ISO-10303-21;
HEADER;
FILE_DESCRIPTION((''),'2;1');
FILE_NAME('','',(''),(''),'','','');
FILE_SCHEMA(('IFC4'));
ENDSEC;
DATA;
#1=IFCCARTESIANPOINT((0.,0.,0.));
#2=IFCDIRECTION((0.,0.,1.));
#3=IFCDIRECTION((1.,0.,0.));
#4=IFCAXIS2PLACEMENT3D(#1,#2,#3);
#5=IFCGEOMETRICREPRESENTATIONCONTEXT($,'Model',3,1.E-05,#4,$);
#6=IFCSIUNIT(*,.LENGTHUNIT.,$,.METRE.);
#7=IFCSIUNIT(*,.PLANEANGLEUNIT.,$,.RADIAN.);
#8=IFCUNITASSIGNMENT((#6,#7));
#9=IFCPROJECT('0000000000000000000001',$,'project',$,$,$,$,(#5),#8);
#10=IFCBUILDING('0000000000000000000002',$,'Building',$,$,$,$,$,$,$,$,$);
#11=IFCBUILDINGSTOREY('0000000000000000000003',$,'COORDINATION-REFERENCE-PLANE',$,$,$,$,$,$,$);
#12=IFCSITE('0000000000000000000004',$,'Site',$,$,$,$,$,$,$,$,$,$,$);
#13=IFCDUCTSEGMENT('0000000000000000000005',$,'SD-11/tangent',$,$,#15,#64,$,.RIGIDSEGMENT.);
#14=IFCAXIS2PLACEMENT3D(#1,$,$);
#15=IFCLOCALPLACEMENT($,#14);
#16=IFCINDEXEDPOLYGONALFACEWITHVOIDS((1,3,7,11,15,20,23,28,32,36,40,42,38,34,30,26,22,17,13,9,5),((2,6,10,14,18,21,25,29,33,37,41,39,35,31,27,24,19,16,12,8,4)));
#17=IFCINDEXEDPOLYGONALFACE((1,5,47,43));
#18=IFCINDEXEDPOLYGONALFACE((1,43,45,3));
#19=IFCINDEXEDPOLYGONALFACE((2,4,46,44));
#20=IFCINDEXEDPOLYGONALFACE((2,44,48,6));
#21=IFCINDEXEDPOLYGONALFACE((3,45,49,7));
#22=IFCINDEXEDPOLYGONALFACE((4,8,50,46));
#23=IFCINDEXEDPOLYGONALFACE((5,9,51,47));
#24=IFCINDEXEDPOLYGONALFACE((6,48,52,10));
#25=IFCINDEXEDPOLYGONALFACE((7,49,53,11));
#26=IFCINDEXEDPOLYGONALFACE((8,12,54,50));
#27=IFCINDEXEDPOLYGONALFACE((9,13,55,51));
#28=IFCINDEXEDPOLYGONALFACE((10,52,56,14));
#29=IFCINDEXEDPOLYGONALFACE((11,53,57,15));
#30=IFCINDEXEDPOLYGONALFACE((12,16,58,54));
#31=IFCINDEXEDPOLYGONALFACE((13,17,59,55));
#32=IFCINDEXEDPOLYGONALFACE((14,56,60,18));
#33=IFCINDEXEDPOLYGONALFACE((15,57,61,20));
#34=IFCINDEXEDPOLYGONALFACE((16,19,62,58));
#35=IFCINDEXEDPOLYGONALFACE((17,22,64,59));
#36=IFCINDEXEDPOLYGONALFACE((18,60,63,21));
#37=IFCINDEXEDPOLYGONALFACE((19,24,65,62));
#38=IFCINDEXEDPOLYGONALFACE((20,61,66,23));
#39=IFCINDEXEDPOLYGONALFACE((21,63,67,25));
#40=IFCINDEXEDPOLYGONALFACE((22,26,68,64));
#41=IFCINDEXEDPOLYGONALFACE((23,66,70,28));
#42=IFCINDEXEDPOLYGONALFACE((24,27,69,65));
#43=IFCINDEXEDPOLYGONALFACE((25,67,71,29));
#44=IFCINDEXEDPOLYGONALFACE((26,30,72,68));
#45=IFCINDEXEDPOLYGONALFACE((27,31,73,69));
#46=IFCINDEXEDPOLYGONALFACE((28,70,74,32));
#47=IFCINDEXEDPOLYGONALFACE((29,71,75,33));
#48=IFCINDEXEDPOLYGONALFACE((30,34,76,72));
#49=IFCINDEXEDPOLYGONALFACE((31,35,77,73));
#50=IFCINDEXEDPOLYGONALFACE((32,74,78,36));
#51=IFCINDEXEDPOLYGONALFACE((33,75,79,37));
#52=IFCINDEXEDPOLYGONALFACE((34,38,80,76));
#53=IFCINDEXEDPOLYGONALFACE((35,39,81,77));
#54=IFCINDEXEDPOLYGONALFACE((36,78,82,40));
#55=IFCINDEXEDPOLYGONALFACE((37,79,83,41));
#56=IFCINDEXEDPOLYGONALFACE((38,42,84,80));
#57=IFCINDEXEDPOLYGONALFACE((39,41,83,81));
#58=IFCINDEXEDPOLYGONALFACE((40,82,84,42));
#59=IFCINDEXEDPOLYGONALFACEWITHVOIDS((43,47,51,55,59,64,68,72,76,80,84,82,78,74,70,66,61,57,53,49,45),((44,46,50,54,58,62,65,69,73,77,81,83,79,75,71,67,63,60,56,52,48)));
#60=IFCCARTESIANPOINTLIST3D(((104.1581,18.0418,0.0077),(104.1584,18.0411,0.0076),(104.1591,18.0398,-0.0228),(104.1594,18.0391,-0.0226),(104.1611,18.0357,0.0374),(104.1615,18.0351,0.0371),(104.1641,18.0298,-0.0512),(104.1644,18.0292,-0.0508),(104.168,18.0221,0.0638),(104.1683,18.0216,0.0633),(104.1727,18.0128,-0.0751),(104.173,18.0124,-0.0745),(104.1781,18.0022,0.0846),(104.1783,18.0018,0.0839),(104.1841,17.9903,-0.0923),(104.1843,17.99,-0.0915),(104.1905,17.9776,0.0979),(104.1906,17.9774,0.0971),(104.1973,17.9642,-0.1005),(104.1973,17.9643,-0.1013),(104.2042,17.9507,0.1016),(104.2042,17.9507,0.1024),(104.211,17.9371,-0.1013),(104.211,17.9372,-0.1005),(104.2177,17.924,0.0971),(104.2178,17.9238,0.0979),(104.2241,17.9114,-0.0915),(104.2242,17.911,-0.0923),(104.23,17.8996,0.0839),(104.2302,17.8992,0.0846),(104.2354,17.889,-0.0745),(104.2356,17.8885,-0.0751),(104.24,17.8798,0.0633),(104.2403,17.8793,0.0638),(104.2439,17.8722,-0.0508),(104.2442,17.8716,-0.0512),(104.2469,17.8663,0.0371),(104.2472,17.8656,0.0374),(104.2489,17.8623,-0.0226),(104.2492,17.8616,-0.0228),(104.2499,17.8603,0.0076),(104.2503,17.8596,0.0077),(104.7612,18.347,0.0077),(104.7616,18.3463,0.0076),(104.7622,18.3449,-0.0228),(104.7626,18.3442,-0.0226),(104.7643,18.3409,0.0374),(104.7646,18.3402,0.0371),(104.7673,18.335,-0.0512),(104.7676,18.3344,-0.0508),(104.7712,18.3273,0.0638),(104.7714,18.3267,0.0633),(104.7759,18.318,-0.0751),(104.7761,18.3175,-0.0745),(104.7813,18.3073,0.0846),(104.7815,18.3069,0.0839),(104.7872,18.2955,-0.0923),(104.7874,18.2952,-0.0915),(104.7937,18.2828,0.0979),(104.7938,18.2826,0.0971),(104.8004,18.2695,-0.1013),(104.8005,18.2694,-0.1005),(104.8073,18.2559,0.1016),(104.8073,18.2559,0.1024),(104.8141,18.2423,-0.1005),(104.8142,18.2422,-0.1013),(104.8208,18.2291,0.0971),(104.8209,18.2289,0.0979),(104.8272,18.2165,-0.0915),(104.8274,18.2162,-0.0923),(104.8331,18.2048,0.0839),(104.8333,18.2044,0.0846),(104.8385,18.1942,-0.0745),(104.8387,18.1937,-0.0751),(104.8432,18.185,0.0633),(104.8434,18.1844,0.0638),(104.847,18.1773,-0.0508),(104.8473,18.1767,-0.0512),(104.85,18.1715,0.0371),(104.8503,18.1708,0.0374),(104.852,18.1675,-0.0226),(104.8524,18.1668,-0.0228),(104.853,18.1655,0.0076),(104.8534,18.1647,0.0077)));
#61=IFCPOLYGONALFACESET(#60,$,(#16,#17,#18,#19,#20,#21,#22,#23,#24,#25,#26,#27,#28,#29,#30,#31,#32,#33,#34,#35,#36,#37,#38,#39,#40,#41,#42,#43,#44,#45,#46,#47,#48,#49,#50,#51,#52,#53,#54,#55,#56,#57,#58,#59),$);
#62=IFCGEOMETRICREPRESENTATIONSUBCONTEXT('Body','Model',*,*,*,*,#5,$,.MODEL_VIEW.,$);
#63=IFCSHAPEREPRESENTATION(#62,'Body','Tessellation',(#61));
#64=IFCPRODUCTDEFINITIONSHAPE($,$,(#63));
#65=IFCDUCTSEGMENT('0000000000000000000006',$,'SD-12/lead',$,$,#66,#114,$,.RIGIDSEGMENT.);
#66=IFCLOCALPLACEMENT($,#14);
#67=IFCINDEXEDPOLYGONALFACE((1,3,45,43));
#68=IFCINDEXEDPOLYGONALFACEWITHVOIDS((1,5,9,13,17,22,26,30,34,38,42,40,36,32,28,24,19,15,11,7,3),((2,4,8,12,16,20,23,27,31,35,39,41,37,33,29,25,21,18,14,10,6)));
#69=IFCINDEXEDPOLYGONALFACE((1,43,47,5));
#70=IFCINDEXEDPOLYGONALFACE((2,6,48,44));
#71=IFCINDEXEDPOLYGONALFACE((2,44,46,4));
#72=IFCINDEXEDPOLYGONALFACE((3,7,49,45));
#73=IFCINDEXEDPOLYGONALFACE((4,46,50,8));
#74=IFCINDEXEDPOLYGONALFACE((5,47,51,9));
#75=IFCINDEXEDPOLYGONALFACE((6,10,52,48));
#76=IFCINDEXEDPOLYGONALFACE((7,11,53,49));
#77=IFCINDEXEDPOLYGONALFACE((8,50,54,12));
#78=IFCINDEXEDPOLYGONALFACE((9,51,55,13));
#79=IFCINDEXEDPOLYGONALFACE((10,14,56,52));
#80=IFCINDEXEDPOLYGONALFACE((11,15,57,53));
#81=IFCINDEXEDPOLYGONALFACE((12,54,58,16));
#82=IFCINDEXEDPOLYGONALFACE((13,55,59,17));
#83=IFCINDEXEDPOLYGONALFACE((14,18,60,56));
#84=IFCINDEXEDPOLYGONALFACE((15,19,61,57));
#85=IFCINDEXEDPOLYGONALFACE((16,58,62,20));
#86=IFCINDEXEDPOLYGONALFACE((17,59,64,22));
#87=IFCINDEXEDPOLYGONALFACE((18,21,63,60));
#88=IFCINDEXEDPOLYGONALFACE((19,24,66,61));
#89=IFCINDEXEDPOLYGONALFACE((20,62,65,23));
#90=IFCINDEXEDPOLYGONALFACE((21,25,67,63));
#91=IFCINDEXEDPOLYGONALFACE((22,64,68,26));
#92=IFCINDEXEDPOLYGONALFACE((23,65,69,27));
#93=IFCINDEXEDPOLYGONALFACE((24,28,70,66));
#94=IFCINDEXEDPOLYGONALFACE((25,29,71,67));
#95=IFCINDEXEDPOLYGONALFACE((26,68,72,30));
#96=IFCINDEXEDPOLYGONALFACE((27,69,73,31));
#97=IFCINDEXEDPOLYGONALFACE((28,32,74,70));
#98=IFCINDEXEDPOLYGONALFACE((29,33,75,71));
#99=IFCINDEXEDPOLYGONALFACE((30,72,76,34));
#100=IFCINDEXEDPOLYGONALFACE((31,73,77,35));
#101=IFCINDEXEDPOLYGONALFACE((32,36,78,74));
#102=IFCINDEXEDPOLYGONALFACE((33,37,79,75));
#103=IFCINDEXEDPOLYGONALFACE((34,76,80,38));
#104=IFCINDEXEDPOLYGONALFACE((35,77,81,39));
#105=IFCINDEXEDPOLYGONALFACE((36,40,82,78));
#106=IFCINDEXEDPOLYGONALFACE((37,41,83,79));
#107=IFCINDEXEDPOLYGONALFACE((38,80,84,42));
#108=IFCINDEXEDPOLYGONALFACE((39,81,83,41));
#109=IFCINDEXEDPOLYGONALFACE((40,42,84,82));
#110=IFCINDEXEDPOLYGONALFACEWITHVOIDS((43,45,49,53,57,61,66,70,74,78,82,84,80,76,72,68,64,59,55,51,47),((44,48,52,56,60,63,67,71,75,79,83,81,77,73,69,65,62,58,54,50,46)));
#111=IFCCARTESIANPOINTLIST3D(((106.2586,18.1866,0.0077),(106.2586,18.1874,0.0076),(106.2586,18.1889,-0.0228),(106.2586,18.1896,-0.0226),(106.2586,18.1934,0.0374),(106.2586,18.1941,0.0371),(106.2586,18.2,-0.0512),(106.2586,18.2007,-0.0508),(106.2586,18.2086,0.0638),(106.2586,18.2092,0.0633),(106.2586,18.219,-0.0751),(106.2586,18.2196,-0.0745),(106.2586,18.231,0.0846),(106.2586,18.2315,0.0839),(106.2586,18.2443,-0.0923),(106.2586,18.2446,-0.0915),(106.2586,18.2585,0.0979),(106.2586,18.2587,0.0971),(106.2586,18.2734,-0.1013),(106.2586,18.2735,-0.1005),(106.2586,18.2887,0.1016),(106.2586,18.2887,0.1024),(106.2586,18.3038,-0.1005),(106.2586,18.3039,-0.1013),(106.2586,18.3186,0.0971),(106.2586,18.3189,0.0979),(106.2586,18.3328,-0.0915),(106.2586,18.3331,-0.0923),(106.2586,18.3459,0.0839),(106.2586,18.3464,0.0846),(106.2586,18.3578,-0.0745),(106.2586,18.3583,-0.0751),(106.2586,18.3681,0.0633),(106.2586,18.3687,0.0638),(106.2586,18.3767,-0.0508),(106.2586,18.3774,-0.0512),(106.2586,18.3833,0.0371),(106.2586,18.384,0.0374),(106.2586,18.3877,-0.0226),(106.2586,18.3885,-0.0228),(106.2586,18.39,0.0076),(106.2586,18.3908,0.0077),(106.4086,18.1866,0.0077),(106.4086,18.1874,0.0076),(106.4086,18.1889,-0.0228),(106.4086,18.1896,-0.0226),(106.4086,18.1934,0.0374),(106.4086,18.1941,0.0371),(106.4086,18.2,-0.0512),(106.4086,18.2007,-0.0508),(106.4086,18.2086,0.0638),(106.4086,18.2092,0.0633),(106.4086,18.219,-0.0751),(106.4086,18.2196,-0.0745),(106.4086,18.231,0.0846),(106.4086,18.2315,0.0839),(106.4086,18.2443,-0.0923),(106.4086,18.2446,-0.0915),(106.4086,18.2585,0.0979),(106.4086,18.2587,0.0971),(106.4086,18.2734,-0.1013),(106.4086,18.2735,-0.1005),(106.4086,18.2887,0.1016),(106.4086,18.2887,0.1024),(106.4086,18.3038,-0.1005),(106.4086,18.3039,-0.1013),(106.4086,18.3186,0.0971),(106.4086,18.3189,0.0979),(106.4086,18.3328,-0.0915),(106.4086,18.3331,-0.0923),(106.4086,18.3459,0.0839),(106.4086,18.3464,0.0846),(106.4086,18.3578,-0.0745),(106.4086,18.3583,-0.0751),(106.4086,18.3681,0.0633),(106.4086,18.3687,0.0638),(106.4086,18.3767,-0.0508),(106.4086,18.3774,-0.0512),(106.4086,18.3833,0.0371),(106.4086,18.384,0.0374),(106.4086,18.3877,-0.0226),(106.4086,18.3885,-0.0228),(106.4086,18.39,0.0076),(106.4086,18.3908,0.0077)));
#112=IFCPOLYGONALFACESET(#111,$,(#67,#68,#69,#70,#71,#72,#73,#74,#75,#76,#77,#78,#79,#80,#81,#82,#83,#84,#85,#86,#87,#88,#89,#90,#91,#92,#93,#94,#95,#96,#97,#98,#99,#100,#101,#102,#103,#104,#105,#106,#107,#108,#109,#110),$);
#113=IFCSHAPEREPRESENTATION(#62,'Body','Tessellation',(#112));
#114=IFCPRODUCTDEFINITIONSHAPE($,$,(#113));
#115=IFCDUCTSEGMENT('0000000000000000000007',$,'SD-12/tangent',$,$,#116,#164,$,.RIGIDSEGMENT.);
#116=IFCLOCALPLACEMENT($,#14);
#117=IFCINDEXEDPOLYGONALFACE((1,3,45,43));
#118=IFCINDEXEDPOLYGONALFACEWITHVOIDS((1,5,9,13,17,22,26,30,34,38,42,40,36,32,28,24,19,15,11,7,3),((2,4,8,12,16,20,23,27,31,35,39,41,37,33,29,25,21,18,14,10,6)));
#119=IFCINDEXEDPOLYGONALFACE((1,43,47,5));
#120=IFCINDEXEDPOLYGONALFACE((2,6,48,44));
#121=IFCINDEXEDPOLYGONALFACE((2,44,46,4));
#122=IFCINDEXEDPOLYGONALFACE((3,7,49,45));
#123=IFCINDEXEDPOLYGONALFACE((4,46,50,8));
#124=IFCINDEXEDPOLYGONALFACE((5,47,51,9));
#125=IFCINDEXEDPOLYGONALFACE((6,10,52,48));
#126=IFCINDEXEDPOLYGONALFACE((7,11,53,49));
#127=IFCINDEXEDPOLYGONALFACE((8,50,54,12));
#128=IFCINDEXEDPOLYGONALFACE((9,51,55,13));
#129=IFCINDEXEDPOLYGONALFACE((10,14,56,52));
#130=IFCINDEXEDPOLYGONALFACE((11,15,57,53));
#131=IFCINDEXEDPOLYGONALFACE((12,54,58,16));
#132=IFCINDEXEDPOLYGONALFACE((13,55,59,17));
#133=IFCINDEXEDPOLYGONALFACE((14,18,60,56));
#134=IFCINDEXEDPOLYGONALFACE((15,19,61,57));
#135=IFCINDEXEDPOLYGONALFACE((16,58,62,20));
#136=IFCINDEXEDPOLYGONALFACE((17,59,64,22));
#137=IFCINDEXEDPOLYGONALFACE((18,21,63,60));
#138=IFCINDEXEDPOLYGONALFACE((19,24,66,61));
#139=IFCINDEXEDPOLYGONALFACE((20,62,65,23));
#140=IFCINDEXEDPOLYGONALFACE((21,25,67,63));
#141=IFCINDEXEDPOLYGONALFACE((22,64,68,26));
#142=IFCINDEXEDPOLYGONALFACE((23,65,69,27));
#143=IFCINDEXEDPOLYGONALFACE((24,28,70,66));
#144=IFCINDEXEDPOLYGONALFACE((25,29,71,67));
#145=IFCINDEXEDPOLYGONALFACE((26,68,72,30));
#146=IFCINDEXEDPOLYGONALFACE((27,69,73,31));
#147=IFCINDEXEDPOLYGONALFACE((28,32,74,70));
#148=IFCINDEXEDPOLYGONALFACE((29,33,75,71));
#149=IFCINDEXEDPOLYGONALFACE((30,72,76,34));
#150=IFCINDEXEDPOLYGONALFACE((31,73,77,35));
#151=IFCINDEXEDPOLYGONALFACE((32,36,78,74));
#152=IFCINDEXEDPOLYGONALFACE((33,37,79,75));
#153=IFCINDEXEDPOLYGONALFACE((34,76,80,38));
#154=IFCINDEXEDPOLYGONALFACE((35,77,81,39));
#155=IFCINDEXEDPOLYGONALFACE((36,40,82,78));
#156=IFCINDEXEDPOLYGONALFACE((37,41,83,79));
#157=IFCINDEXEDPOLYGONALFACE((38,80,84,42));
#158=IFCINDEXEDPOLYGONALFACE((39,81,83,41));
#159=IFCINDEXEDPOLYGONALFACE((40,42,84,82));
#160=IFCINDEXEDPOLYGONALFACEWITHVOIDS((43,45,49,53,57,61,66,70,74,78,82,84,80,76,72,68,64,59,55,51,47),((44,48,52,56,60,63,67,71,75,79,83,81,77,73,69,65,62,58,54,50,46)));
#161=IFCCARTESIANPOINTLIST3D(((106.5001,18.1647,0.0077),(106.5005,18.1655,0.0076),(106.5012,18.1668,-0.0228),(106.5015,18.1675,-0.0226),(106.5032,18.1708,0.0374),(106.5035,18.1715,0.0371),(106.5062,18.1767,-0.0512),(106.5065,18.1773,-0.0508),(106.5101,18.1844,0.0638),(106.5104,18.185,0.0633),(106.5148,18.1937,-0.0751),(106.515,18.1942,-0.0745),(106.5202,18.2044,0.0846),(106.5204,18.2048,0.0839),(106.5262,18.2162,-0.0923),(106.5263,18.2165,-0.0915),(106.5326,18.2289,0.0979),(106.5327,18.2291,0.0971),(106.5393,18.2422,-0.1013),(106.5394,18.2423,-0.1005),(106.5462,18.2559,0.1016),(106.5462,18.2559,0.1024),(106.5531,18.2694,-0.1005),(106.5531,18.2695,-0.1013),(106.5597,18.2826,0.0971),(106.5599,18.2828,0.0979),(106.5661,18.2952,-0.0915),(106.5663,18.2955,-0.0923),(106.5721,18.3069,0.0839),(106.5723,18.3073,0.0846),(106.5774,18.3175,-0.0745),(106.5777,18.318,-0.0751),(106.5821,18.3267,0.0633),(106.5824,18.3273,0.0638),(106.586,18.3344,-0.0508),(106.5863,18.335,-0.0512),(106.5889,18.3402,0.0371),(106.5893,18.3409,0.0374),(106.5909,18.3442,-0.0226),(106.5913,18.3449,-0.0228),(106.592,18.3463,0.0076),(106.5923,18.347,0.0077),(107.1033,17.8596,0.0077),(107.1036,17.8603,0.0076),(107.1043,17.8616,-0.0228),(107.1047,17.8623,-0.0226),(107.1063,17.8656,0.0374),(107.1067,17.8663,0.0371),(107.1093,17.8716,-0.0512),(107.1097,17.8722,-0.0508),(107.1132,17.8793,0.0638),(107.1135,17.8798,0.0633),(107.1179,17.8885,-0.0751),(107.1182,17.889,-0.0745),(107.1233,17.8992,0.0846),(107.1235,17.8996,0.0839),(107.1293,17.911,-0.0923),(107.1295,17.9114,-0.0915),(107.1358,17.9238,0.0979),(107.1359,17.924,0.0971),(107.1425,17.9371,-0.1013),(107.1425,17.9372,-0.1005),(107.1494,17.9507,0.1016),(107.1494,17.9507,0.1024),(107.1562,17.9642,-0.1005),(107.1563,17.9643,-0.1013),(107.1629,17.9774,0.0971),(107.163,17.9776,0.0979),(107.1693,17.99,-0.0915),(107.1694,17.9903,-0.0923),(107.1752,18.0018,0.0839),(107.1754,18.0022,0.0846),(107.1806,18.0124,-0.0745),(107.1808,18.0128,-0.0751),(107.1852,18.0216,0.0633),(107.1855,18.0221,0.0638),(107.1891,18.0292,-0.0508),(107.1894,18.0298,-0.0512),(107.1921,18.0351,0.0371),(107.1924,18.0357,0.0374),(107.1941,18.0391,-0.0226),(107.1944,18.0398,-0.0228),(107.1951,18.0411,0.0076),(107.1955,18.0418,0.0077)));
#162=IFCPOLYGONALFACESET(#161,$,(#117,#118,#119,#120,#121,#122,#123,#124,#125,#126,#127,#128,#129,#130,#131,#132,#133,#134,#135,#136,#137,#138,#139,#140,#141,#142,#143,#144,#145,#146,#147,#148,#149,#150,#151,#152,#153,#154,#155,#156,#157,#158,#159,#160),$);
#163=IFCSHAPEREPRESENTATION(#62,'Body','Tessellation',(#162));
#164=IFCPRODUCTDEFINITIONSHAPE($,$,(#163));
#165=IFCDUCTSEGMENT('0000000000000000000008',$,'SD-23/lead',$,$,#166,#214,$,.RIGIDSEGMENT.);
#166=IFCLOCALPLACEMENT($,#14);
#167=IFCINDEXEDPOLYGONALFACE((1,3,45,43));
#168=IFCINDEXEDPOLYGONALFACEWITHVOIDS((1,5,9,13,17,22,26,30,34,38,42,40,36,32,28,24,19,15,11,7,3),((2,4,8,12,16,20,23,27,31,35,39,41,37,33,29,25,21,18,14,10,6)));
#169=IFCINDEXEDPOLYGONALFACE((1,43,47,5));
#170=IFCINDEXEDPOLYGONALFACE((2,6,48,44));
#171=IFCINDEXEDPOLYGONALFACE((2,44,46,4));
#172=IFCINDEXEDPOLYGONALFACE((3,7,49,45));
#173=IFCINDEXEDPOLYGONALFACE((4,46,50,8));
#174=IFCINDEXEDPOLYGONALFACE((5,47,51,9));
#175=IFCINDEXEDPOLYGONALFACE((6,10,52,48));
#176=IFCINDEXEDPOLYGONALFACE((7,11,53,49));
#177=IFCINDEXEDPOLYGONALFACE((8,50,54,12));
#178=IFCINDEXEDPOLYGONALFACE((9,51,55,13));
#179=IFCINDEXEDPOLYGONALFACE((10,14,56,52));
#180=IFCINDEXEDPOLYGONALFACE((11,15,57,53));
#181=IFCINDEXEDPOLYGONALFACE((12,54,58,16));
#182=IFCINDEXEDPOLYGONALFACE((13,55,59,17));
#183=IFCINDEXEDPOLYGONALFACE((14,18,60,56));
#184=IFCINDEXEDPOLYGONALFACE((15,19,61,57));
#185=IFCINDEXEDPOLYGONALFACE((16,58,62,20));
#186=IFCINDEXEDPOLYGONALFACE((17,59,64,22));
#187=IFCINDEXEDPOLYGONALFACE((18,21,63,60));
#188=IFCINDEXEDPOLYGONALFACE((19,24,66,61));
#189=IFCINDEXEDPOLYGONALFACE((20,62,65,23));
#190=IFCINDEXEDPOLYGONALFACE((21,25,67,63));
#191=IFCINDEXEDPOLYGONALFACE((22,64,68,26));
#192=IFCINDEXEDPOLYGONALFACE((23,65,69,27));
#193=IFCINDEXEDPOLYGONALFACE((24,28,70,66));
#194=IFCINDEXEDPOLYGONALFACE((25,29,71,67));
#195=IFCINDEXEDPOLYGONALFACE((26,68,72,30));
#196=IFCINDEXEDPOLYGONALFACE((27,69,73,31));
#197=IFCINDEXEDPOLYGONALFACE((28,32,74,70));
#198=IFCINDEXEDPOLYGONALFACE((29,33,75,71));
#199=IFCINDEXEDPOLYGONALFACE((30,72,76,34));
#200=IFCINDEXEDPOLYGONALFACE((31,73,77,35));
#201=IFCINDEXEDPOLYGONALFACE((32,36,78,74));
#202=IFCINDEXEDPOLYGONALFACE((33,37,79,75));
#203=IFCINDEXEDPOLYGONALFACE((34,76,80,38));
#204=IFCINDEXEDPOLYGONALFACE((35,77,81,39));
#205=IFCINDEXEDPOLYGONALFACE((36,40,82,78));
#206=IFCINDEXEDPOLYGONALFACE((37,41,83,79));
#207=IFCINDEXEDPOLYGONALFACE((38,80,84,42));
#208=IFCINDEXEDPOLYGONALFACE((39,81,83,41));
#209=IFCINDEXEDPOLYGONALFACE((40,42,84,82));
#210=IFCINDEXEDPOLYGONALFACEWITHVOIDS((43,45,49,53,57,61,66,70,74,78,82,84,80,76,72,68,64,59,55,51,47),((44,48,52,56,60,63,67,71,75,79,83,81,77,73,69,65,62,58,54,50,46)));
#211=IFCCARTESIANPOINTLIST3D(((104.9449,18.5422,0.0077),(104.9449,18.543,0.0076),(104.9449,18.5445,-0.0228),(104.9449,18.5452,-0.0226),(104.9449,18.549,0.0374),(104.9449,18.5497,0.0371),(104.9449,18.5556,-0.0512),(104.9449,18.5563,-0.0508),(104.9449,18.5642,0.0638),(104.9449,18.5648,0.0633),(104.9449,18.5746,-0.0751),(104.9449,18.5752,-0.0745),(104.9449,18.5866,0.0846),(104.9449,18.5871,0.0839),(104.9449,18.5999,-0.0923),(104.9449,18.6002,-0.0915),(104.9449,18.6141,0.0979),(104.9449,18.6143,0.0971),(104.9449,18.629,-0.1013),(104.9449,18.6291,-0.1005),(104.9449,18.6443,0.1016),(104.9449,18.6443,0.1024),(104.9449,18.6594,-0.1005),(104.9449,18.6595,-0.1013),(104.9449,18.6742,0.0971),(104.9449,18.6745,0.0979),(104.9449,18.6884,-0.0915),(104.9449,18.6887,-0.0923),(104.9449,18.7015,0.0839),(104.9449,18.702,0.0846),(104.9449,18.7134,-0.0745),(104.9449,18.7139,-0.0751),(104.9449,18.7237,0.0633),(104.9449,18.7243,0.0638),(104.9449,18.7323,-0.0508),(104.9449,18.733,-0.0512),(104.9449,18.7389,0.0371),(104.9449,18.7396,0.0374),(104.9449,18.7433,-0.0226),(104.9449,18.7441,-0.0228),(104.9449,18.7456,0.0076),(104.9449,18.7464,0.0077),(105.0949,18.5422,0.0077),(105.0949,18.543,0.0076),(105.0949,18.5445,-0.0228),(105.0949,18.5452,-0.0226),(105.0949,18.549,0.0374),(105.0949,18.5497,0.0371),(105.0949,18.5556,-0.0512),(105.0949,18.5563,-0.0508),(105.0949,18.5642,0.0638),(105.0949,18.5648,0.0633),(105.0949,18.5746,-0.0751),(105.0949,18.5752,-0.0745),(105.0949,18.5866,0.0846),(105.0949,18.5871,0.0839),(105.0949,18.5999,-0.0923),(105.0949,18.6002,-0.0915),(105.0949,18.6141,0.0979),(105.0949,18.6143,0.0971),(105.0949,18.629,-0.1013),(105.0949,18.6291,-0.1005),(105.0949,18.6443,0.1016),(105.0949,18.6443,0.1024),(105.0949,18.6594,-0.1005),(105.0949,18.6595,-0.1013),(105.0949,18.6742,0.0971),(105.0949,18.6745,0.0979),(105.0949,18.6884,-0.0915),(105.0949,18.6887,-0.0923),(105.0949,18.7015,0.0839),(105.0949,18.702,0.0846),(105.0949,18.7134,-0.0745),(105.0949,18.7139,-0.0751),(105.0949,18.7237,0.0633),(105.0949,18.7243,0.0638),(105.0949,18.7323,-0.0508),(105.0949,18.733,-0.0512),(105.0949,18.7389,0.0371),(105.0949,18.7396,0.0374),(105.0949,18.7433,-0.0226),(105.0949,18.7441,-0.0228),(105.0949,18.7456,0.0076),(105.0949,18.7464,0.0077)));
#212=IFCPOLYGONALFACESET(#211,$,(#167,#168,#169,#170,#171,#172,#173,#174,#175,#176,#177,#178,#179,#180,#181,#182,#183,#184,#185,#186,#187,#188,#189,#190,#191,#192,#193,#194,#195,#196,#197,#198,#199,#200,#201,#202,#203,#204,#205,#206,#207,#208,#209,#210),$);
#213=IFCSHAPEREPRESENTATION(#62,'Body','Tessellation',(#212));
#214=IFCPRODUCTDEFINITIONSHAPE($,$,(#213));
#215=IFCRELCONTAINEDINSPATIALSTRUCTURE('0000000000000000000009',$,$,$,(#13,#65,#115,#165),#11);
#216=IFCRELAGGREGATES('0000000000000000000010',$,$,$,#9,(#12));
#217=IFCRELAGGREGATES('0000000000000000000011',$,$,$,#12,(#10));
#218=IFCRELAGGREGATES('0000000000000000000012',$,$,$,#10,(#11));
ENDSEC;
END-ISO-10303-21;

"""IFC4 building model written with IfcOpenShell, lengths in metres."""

from ifc_helpers import new_model, si_unit, frame, origin_with_axes, place, context, subcontext, project, spatial, hollow_circle, extrude, element, save


model = new_model("IFC4")

# Units and contexts
model_context = context("Model", 3, precision=1e-05, world=origin_with_axes())
body_context_1 = subcontext(model_context, "Body", "Model", "MODEL_VIEW")
ifc_project = project(units=[si_unit("LENGTHUNIT", "METRE"), si_unit("PLANEANGLEUNIT", "RADIAN")], contexts=[model_context])

# Site, building, storey
site = spatial("IfcSite", under=ifc_project, Name="Site")
building = spatial("IfcBuilding", under=site, Name="Building")
storey = spatial("IfcBuildingStorey", under=building, Name="COORDINATION-REFERENCE-PLANE")

# Duct segment
duct_segment_1_placement = place(None, frame((104.8073, 18.2559, 0.0), z_axis=(-0.892292, -0.451458, 0.0), x_axis=(0.0, 0.0, 1.0)))
element("IfcDuctSegment", 1, at=duct_segment_1_placement, inside=storey, Name="SD-11/tangent", PredefinedType="RIGIDSEGMENT", context=body_context_1, shape_type="SweptSolid", body=[
    extrude(hollow_circle(Radius=0.1024, WallThickness=0.0008), origin_with_axes(), (0.0, 0.0, 1.0), 0.676),
])

# Duct segment
duct_segment_2_placement = place(None, frame((106.2586, 18.2887, 0.0), z_axis=(1.0, 0.0, 0.0), x_axis=(0.0, 0.0, 1.0)))
element("IfcDuctSegment", 2, at=duct_segment_2_placement, inside=storey, Name="SD-12/lead", PredefinedType="RIGIDSEGMENT", context=body_context_1, shape_type="SweptSolid", body=[
    extrude(hollow_circle(Radius=0.1024, WallThickness=0.0008), origin_with_axes(), (0.0, 0.0, 1.0), 0.15),
])

# Duct segment
duct_segment_3_placement = place(None, frame((106.5462, 18.2559, 0.0), z_axis=(0.892292, -0.451458, 0.0), x_axis=(0.0, 0.0, 1.0)))
element("IfcDuctSegment", 3, at=duct_segment_3_placement, inside=storey, Name="SD-12/tangent", PredefinedType="RIGIDSEGMENT", context=body_context_1, shape_type="SweptSolid", body=[
    extrude(hollow_circle(Radius=0.1024, WallThickness=0.0008), origin_with_axes(), (0.0, 0.0, 1.0), 0.676),
])

# Duct segment
duct_segment_4_placement = place(None, frame((105.0949, 18.6443, 0.0), z_axis=(-1.0, 0.0, 0.0), x_axis=(0.0, 0.0, 1.0)))
element("IfcDuctSegment", 4, at=duct_segment_4_placement, inside=storey, Name="SD-23/lead", PredefinedType="RIGIDSEGMENT", context=body_context_1, shape_type="SweptSolid", body=[
    extrude(hollow_circle(Radius=0.1024, WallThickness=0.0008), origin_with_axes(), (0.0, 0.0, 1.0), 0.15),
])

save(model, "model.ifc")
